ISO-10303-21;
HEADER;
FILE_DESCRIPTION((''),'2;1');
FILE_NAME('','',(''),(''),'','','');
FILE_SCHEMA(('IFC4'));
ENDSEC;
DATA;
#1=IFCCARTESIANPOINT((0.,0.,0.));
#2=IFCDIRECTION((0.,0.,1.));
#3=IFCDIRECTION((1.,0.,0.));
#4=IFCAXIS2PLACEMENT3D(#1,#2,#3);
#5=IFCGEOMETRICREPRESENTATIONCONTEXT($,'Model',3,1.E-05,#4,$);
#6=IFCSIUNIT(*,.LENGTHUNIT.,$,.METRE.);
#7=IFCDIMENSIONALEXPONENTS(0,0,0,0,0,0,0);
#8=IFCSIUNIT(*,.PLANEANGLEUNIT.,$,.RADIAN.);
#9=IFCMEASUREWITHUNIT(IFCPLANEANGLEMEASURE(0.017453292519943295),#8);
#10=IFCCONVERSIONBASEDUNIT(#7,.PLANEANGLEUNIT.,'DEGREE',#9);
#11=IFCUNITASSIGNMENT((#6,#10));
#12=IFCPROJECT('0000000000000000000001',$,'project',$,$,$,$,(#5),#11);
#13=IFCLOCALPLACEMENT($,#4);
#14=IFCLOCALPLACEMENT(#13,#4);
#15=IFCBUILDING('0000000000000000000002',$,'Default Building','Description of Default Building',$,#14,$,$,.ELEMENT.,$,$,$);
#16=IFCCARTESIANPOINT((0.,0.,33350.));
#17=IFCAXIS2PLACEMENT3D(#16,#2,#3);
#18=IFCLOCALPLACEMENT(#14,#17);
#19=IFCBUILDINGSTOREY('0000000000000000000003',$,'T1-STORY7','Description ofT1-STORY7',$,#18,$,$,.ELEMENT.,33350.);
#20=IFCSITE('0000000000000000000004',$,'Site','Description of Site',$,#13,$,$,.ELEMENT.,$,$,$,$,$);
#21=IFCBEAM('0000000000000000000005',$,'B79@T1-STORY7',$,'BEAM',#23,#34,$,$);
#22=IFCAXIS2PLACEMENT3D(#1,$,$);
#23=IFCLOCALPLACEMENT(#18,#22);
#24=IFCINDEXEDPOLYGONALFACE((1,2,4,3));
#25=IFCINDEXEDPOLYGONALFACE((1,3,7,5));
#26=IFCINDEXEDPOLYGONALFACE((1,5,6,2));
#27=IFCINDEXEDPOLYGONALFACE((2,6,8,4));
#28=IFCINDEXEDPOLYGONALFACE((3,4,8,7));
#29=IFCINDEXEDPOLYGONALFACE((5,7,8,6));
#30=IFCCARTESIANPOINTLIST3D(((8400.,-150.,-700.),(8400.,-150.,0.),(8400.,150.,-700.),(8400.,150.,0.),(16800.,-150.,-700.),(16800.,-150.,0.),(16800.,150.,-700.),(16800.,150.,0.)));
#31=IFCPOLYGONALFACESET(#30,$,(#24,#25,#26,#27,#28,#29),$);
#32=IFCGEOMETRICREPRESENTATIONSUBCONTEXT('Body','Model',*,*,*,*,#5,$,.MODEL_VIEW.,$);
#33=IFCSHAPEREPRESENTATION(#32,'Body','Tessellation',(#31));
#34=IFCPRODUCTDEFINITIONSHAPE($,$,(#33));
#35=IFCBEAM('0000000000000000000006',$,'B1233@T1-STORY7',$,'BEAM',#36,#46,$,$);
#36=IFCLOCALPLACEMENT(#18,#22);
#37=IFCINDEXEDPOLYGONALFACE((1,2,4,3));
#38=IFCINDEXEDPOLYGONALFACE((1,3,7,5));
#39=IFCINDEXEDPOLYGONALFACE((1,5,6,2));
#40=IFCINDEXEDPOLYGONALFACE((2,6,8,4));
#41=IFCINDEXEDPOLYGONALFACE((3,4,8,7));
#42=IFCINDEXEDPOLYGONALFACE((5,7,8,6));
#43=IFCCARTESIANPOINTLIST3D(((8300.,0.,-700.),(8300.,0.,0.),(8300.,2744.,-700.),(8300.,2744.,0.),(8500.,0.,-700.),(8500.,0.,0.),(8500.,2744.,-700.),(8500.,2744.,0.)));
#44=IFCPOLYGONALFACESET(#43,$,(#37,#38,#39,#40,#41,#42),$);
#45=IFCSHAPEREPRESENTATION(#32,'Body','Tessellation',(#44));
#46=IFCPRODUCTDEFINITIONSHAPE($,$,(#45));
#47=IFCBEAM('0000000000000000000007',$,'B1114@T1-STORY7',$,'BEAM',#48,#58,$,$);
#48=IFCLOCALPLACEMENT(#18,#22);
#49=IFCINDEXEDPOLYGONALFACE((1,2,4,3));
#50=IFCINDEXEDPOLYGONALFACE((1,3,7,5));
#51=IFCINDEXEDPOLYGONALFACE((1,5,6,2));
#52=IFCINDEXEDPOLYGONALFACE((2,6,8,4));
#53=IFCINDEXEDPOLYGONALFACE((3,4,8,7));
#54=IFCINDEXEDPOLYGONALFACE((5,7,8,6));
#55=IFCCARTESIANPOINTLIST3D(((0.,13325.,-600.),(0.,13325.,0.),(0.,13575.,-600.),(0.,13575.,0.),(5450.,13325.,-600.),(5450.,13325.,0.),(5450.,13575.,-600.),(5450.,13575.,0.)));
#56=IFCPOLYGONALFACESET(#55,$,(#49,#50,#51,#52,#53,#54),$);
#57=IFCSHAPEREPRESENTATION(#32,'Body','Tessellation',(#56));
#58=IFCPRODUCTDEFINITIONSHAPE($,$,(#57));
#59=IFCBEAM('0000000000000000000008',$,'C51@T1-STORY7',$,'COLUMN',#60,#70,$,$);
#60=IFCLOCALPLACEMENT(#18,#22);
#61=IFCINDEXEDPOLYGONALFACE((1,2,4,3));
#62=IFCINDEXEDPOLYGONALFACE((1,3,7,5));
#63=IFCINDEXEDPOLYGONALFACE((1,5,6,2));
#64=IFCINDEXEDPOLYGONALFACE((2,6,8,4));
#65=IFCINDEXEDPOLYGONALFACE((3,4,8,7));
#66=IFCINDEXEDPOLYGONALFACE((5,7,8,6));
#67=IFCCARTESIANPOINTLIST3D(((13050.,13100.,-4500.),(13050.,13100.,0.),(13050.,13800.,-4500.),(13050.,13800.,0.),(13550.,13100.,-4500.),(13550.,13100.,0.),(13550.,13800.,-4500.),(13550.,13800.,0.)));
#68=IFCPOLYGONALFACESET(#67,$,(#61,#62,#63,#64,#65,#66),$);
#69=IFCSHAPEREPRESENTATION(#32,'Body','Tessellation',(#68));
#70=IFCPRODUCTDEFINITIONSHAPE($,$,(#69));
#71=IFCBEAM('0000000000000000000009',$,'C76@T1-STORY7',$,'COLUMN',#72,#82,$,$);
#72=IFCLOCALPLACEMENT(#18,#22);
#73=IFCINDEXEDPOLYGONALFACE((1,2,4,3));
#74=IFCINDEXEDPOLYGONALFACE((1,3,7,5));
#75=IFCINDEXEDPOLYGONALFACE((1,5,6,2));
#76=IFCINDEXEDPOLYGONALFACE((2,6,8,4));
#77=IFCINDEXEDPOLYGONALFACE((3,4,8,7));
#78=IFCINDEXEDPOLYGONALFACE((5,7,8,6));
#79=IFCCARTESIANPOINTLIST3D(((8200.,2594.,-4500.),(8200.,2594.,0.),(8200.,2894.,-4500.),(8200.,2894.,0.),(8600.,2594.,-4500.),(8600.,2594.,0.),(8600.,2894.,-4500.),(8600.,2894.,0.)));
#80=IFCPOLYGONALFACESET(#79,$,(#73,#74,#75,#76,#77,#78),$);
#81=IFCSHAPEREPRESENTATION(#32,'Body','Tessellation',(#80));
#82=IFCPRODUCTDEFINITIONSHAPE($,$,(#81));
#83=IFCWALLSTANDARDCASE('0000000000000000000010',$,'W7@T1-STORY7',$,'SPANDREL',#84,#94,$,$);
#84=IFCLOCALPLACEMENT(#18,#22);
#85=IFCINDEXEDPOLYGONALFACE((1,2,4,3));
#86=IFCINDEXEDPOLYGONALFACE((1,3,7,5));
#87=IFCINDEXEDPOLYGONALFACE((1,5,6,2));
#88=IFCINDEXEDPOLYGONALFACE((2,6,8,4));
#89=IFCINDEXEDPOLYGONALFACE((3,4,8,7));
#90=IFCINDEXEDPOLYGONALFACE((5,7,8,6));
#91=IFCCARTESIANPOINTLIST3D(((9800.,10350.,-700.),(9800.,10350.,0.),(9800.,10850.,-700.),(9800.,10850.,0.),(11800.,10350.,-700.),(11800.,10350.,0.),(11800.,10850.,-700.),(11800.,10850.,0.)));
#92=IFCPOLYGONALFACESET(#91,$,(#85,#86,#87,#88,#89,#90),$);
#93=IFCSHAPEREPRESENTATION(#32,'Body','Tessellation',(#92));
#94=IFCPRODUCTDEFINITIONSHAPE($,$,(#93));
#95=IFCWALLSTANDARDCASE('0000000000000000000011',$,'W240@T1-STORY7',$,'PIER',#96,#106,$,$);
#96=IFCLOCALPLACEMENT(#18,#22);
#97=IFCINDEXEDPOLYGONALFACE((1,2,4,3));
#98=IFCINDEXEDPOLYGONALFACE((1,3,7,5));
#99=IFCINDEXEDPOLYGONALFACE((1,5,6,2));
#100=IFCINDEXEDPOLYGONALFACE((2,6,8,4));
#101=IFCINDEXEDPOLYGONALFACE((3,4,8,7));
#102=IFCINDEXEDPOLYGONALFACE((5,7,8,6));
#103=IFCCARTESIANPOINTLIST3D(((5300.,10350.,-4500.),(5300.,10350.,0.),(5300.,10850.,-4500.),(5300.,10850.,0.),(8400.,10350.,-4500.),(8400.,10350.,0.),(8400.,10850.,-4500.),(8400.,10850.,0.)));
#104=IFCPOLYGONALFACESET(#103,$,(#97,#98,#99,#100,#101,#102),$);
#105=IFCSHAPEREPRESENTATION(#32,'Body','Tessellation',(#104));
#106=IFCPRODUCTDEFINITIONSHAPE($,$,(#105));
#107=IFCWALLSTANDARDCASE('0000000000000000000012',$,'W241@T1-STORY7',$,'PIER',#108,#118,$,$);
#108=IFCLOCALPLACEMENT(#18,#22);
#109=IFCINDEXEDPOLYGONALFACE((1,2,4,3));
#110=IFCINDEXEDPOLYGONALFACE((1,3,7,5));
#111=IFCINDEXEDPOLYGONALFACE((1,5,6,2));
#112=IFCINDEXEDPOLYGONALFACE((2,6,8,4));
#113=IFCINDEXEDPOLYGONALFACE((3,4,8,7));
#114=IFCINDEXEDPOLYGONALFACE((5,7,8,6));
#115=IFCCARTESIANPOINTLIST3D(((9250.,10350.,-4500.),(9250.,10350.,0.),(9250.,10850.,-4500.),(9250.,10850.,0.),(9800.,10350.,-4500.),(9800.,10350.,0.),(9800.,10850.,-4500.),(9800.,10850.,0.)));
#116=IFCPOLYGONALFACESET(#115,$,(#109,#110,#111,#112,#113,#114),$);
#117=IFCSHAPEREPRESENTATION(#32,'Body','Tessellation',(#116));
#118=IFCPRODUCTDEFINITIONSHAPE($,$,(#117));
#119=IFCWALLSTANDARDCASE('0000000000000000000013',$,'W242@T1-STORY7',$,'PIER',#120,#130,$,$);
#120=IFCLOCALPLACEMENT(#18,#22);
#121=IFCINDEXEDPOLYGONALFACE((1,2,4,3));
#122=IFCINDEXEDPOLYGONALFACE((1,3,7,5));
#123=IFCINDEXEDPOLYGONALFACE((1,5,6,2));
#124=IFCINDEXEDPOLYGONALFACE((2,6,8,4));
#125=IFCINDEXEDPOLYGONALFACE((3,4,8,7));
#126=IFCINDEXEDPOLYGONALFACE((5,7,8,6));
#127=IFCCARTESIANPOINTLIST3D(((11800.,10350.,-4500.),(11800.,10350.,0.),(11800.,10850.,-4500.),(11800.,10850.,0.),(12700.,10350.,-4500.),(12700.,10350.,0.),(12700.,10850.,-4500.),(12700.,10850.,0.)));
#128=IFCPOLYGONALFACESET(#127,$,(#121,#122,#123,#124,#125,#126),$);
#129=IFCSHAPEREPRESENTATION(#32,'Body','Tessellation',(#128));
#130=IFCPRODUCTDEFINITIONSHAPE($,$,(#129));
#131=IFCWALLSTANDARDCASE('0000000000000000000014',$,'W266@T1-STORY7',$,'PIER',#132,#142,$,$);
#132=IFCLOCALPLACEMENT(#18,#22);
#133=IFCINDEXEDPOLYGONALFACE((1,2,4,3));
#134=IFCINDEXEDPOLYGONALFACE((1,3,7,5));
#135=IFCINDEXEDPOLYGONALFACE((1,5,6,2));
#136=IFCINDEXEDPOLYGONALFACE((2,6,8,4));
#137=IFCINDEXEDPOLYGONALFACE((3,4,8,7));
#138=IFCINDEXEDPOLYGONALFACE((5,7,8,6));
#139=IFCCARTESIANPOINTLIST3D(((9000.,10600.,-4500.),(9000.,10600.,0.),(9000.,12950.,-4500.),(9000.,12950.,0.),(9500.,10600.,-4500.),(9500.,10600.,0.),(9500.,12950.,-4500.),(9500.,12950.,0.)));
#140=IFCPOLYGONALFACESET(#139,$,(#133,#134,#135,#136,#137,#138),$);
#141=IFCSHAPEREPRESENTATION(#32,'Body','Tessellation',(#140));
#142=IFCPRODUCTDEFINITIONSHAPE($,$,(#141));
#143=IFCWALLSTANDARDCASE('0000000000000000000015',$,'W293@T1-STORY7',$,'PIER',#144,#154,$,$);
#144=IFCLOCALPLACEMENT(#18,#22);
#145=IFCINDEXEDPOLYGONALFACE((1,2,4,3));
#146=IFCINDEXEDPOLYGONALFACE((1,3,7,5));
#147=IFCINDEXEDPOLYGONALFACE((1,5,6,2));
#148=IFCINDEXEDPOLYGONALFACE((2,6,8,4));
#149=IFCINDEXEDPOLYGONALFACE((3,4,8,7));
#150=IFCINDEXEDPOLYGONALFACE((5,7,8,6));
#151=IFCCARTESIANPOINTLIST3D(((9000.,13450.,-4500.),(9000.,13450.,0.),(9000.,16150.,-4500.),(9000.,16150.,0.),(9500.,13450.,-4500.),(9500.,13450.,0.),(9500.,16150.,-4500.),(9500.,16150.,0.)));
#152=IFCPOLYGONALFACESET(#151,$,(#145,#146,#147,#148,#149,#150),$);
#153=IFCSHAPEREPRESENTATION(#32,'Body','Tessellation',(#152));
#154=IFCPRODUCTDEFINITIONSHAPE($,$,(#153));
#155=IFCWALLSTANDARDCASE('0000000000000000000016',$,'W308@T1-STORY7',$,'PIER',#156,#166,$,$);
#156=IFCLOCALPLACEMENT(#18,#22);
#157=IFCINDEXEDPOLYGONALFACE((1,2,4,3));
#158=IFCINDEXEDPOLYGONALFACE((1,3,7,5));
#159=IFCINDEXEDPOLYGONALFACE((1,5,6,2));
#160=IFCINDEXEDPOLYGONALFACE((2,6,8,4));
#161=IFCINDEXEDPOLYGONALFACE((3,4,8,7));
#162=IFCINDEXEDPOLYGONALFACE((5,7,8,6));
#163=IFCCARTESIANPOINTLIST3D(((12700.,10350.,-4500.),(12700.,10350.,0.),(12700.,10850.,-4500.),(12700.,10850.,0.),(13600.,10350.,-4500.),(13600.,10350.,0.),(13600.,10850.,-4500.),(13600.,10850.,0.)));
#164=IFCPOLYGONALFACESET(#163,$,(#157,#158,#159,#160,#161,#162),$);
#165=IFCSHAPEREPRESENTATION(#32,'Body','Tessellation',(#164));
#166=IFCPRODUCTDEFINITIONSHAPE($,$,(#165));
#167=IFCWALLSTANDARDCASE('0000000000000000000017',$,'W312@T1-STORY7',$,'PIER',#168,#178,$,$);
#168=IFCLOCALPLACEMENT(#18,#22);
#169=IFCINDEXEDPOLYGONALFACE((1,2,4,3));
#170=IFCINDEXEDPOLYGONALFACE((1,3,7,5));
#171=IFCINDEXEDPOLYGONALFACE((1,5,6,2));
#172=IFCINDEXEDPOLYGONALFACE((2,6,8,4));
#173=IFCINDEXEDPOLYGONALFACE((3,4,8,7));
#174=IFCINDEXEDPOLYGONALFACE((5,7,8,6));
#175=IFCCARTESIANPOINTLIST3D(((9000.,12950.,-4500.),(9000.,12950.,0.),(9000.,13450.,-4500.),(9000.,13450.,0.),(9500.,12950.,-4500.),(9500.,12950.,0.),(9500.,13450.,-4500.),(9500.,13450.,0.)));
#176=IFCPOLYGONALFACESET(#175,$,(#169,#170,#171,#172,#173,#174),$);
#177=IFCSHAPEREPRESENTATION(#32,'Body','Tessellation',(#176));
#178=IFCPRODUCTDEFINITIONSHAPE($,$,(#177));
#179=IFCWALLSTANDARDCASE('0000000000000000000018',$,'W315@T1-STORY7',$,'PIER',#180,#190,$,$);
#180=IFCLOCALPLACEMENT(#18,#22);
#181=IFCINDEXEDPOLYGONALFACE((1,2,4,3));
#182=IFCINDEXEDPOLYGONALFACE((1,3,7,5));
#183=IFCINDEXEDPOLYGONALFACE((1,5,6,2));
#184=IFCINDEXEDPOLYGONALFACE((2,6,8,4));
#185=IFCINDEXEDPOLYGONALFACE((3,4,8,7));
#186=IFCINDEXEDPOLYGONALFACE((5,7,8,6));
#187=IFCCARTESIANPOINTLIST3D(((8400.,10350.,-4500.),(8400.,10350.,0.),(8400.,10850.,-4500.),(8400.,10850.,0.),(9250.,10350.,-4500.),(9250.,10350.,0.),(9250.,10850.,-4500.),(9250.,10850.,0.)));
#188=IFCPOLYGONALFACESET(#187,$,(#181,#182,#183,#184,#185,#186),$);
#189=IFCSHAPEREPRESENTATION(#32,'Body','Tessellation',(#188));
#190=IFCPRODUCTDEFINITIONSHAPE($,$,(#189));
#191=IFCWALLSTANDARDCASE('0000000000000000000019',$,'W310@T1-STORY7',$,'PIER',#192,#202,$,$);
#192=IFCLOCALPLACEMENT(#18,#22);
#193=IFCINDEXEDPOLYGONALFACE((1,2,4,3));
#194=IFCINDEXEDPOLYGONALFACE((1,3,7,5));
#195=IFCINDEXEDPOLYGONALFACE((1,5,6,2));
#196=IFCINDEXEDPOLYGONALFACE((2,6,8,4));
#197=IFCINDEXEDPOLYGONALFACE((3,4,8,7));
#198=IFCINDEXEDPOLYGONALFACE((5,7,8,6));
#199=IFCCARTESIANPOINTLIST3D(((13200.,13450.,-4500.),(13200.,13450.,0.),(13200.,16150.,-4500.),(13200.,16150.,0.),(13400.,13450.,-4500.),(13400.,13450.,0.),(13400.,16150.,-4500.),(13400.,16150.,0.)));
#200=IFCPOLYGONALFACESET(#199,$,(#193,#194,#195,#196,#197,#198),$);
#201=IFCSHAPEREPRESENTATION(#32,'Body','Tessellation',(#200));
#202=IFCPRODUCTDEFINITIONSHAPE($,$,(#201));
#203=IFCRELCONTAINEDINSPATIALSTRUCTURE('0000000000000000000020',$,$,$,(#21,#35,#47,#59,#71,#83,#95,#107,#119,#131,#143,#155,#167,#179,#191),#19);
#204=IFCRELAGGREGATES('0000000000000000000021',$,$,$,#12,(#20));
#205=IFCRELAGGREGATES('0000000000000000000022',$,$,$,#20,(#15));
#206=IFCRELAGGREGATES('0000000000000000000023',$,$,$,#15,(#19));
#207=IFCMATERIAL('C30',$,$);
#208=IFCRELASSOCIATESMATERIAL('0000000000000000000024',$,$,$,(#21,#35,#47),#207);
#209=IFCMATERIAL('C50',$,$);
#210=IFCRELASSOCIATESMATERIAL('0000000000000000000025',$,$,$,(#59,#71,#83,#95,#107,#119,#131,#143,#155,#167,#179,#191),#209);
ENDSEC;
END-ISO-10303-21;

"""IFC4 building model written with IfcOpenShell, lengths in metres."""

from ifc_helpers import new_model, entity, si_unit, converted_unit, frame, origin_with_axes, place, context, subcontext, project, spatial, indexed_curve, rectangle, outline, extrude, material, element, save


model = new_model("IFC4")

# Units and contexts
model_context = context("Model", 3, precision=1e-05, world=origin_with_axes())
body_context = subcontext(model_context, "Body", "Model", "MODEL_VIEW")
ifc_project = project(units=[si_unit("LENGTHUNIT", "METRE"), converted_unit("PLANEANGLEUNIT", "DEGREE", entity("IfcPlaneAngleMeasure", 0.017453292519943295), si_unit("PLANEANGLEUNIT", "RADIAN"), dimensions=[0, 0, 0, 0, 0, 0, 0])], contexts=[model_context])

# Site, building, storey
site_placement = place(None, origin_with_axes())
site = spatial("IfcSite", under=ifc_project, at=site_placement, Name="Site", Description="Description of Site", CompositionType="ELEMENT")
building_placement = place(site_placement, origin_with_axes())
building = spatial("IfcBuilding", under=site, at=building_placement, Name="Default Building", Description="Description of Default Building", CompositionType="ELEMENT")
storey_placement = place(building_placement, frame((0.0, 0.0, 33350.0), z_axis=(0.0, 0.0, 1.0), x_axis=(1.0, 0.0, 0.0)))
storey = spatial("IfcBuildingStorey", under=building, at=storey_placement, Name="T1-STORY7", Description="Description ofT1-STORY7", CompositionType="ELEMENT", Elevation=33350.0)

# Beams
ifc_material_1 = material(Name="C30")
beam_1_placement = place(storey_placement, frame((8400.0, 0.0, -350.0), z_axis=(1.0, 0.0, 0.0), x_axis=(0.0, 1.0, 0.0)))
element("IfcBeam", 1, at=beam_1_placement, inside=storey, material=ifc_material_1, Name="B79@T1-STORY7", ObjectType="BEAM", context=body_context, shape_type="SweptSolid", body=[
    extrude(rectangle(XDim=300.0, YDim=700.0), origin_with_axes(), (0.0, 0.0, 1.0), 8400.0),
])
beam_2_placement = place(storey_placement, frame((8400.0, 0.0, -350.0), z_axis=(0.0, 1.0, 0.0), x_axis=(-1.0, 0.0, 0.0)))
element("IfcBeam", 2, at=beam_2_placement, inside=storey, material=ifc_material_1, Name="B1233@T1-STORY7", ObjectType="BEAM", context=body_context, shape_type="SweptSolid", body=[
    extrude(rectangle(XDim=200.0, YDim=700.0), origin_with_axes(), (0.0, 0.0, 1.0), 2744.0),
])
beam_3_placement = place(storey_placement, frame((0.0, 13450.0, -300.0), z_axis=(1.0, 0.0, 0.0), x_axis=(0.0, 1.0, 0.0)))
element("IfcBeam", 3, at=beam_3_placement, inside=storey, material=ifc_material_1, Name="B1114@T1-STORY7", ObjectType="BEAM", context=body_context, shape_type="SweptSolid", body=[
    extrude(rectangle(XDim=250.0, YDim=600.0), origin_with_axes(), (0.0, 0.0, 1.0), 5450.0),
])
ifc_material_2 = material(Name="C50")
beam_4_placement = place(storey_placement, frame((13300.0, 13450.0, -4500.0), z_axis=(0.0, 0.0, 1.0), x_axis=(-1.0, 0.0, 0.0)))
element("IfcBeam", 4, at=beam_4_placement, inside=storey, material=ifc_material_2, Name="C51@T1-STORY7", ObjectType="COLUMN", context=body_context, shape_type="SweptSolid", body=[
    extrude(rectangle(XDim=500.0, YDim=700.0), origin_with_axes(), (0.0, 0.0, 1.0), 4500.0),
])
beam_5_placement = place(storey_placement, frame((8400.0, 2744.0, -4500.0), z_axis=(0.0, 0.0, 1.0), x_axis=(-1.0, 0.0, 0.0)))
element("IfcBeam", 5, at=beam_5_placement, inside=storey, material=ifc_material_2, Name="C76@T1-STORY7", ObjectType="COLUMN", context=body_context, shape_type="SweptSolid", body=[
    extrude(rectangle(XDim=400.0, YDim=300.0), origin_with_axes(), (0.0, 0.0, 1.0), 4500.0),
])

# Walls
wall_1_placement = place(storey_placement, frame((9800.0, 10600.0, -700.0), z_axis=(0.0, 0.0, 1.0), x_axis=(1.0, 0.0, 0.0)))
element("IfcWallStandardCase", 6, at=wall_1_placement, inside=storey, material=ifc_material_2, Name="W7@T1-STORY7", ObjectType="SPANDREL", context=body_context, shape_type="SweptSolid", body=[
    extrude(outline(indexed_curve([(0.0, -250.0), (0.0, 250.0), (2000.0, 250.0), (2000.0, -250.0), (0.0, -250.0)], self_intersect=False)), origin_with_axes(), (0.0, 0.0, 1.0), 700.0),
])
wall_2_placement = place(storey_placement, frame((5300.0, 10600.0, -4500.0), z_axis=(0.0, 0.0, 1.0), x_axis=(1.0, 0.0, 0.0)))
element("IfcWallStandardCase", 7, at=wall_2_placement, inside=storey, material=ifc_material_2, Name="W240@T1-STORY7", ObjectType="PIER", context=body_context, shape_type="SweptSolid", body=[
    extrude(outline(indexed_curve([(0.0, -250.0), (0.0, 250.0), (3100.0, 250.0), (3100.0, -250.0), (0.0, -250.0)], self_intersect=False)), origin_with_axes(), (0.0, 0.0, 1.0), 4500.0),
])
wall_3_placement = place(storey_placement, frame((9250.0, 10600.0, -4500.0), z_axis=(0.0, 0.0, 1.0), x_axis=(1.0, 0.0, 0.0)))
element("IfcWallStandardCase", 8, at=wall_3_placement, inside=storey, material=ifc_material_2, Name="W241@T1-STORY7", ObjectType="PIER", context=body_context, shape_type="SweptSolid", body=[
    extrude(outline(indexed_curve([(0.0, -250.0), (0.0, 250.0), (550.0, 250.0), (550.0, -250.0), (0.0, -250.0)], self_intersect=False)), origin_with_axes(), (0.0, 0.0, 1.0), 4500.0),
])
wall_4_placement = place(storey_placement, frame((11800.0, 10600.0, -4500.0), z_axis=(0.0, 0.0, 1.0), x_axis=(1.0, 0.0, 0.0)))
element("IfcWallStandardCase", 9, at=wall_4_placement, inside=storey, material=ifc_material_2, Name="W242@T1-STORY7", ObjectType="PIER", context=body_context, shape_type="SweptSolid", body=[
    extrude(outline(indexed_curve([(0.0, -250.0), (0.0, 250.0), (900.0, 250.0), (900.0, -250.0), (0.0, -250.0)], self_intersect=False)), origin_with_axes(), (0.0, 0.0, 1.0), 4500.0),
])
wall_5_placement = place(storey_placement, frame((9250.0, 10600.0, -4500.0), z_axis=(0.0, 0.0, 1.0), x_axis=(0.0, 1.0, 0.0)))
element("IfcWallStandardCase", 10, at=wall_5_placement, inside=storey, material=ifc_material_2, Name="W266@T1-STORY7", ObjectType="PIER", context=body_context, shape_type="SweptSolid", body=[
    extrude(outline(indexed_curve([(0.0, -250.0), (0.0, 250.0), (2350.0, 250.0), (2350.0, -250.0), (0.0, -250.0)], self_intersect=False)), origin_with_axes(), (0.0, 0.0, 1.0), 4500.0),
])
wall_6_placement = place(storey_placement, frame((9250.0, 13450.0, -4500.0), z_axis=(0.0, 0.0, 1.0), x_axis=(0.0, 1.0, 0.0)))
element("IfcWallStandardCase", 11, at=wall_6_placement, inside=storey, material=ifc_material_2, Name="W293@T1-STORY7", ObjectType="PIER", context=body_context, shape_type="SweptSolid", body=[
    extrude(outline(indexed_curve([(0.0, -250.0), (0.0, 250.0), (2700.0, 250.0), (2700.0, -250.0), (0.0, -250.0)], self_intersect=False)), origin_with_axes(), (0.0, 0.0, 1.0), 4500.0),
])
wall_7_placement = place(storey_placement, frame((12700.0, 10600.0, -4500.0), z_axis=(0.0, 0.0, 1.0), x_axis=(1.0, 0.0, 0.0)))
element("IfcWallStandardCase", 12, at=wall_7_placement, inside=storey, material=ifc_material_2, Name="W308@T1-STORY7", ObjectType="PIER", context=body_context, shape_type="SweptSolid", body=[
    extrude(outline(indexed_curve([(0.0, -250.0), (0.0, 250.0), (900.0, 250.0), (900.0, -250.0), (0.0, -250.0)], self_intersect=False)), origin_with_axes(), (0.0, 0.0, 1.0), 4500.0),
])
wall_8_placement = place(storey_placement, frame((9250.0, 12950.0, -4500.0), z_axis=(0.0, 0.0, 1.0), x_axis=(0.0, 1.0, 0.0)))
element("IfcWallStandardCase", 13, at=wall_8_placement, inside=storey, material=ifc_material_2, Name="W312@T1-STORY7", ObjectType="PIER", context=body_context, shape_type="SweptSolid", body=[
    extrude(outline(indexed_curve([(0.0, -250.0), (0.0, 250.0), (500.0, 250.0), (500.0, -250.0), (0.0, -250.0)], self_intersect=False)), origin_with_axes(), (0.0, 0.0, 1.0), 4500.0),
])
wall_9_placement = place(storey_placement, frame((8400.0, 10600.0, -4500.0), z_axis=(0.0, 0.0, 1.0), x_axis=(1.0, 0.0, 0.0)))
element("IfcWallStandardCase", 14, at=wall_9_placement, inside=storey, material=ifc_material_2, Name="W315@T1-STORY7", ObjectType="PIER", context=body_context, shape_type="SweptSolid", body=[
    extrude(outline(indexed_curve([(0.0, -250.0), (0.0, 250.0), (850.0, 250.0), (850.0, -250.0), (0.0, -250.0)], self_intersect=False)), origin_with_axes(), (0.0, 0.0, 1.0), 4500.0),
])
wall_10_placement = place(storey_placement, frame((13300.0, 13450.0, -4500.0), z_axis=(0.0, 0.0, 1.0), x_axis=(0.0, 1.0, 0.0)))
element("IfcWallStandardCase", 15, at=wall_10_placement, inside=storey, material=ifc_material_2, Name="W310@T1-STORY7", ObjectType="PIER", context=body_context, shape_type="SweptSolid", body=[
    extrude(outline(indexed_curve([(0.0, -100.0), (0.0, 100.0), (2700.0, 100.0), (2700.0, -100.0), (0.0, -100.0)], self_intersect=False)), origin_with_axes(), (0.0, 0.0, 1.0), 4500.0),
])

save(model, "model.ifc")
